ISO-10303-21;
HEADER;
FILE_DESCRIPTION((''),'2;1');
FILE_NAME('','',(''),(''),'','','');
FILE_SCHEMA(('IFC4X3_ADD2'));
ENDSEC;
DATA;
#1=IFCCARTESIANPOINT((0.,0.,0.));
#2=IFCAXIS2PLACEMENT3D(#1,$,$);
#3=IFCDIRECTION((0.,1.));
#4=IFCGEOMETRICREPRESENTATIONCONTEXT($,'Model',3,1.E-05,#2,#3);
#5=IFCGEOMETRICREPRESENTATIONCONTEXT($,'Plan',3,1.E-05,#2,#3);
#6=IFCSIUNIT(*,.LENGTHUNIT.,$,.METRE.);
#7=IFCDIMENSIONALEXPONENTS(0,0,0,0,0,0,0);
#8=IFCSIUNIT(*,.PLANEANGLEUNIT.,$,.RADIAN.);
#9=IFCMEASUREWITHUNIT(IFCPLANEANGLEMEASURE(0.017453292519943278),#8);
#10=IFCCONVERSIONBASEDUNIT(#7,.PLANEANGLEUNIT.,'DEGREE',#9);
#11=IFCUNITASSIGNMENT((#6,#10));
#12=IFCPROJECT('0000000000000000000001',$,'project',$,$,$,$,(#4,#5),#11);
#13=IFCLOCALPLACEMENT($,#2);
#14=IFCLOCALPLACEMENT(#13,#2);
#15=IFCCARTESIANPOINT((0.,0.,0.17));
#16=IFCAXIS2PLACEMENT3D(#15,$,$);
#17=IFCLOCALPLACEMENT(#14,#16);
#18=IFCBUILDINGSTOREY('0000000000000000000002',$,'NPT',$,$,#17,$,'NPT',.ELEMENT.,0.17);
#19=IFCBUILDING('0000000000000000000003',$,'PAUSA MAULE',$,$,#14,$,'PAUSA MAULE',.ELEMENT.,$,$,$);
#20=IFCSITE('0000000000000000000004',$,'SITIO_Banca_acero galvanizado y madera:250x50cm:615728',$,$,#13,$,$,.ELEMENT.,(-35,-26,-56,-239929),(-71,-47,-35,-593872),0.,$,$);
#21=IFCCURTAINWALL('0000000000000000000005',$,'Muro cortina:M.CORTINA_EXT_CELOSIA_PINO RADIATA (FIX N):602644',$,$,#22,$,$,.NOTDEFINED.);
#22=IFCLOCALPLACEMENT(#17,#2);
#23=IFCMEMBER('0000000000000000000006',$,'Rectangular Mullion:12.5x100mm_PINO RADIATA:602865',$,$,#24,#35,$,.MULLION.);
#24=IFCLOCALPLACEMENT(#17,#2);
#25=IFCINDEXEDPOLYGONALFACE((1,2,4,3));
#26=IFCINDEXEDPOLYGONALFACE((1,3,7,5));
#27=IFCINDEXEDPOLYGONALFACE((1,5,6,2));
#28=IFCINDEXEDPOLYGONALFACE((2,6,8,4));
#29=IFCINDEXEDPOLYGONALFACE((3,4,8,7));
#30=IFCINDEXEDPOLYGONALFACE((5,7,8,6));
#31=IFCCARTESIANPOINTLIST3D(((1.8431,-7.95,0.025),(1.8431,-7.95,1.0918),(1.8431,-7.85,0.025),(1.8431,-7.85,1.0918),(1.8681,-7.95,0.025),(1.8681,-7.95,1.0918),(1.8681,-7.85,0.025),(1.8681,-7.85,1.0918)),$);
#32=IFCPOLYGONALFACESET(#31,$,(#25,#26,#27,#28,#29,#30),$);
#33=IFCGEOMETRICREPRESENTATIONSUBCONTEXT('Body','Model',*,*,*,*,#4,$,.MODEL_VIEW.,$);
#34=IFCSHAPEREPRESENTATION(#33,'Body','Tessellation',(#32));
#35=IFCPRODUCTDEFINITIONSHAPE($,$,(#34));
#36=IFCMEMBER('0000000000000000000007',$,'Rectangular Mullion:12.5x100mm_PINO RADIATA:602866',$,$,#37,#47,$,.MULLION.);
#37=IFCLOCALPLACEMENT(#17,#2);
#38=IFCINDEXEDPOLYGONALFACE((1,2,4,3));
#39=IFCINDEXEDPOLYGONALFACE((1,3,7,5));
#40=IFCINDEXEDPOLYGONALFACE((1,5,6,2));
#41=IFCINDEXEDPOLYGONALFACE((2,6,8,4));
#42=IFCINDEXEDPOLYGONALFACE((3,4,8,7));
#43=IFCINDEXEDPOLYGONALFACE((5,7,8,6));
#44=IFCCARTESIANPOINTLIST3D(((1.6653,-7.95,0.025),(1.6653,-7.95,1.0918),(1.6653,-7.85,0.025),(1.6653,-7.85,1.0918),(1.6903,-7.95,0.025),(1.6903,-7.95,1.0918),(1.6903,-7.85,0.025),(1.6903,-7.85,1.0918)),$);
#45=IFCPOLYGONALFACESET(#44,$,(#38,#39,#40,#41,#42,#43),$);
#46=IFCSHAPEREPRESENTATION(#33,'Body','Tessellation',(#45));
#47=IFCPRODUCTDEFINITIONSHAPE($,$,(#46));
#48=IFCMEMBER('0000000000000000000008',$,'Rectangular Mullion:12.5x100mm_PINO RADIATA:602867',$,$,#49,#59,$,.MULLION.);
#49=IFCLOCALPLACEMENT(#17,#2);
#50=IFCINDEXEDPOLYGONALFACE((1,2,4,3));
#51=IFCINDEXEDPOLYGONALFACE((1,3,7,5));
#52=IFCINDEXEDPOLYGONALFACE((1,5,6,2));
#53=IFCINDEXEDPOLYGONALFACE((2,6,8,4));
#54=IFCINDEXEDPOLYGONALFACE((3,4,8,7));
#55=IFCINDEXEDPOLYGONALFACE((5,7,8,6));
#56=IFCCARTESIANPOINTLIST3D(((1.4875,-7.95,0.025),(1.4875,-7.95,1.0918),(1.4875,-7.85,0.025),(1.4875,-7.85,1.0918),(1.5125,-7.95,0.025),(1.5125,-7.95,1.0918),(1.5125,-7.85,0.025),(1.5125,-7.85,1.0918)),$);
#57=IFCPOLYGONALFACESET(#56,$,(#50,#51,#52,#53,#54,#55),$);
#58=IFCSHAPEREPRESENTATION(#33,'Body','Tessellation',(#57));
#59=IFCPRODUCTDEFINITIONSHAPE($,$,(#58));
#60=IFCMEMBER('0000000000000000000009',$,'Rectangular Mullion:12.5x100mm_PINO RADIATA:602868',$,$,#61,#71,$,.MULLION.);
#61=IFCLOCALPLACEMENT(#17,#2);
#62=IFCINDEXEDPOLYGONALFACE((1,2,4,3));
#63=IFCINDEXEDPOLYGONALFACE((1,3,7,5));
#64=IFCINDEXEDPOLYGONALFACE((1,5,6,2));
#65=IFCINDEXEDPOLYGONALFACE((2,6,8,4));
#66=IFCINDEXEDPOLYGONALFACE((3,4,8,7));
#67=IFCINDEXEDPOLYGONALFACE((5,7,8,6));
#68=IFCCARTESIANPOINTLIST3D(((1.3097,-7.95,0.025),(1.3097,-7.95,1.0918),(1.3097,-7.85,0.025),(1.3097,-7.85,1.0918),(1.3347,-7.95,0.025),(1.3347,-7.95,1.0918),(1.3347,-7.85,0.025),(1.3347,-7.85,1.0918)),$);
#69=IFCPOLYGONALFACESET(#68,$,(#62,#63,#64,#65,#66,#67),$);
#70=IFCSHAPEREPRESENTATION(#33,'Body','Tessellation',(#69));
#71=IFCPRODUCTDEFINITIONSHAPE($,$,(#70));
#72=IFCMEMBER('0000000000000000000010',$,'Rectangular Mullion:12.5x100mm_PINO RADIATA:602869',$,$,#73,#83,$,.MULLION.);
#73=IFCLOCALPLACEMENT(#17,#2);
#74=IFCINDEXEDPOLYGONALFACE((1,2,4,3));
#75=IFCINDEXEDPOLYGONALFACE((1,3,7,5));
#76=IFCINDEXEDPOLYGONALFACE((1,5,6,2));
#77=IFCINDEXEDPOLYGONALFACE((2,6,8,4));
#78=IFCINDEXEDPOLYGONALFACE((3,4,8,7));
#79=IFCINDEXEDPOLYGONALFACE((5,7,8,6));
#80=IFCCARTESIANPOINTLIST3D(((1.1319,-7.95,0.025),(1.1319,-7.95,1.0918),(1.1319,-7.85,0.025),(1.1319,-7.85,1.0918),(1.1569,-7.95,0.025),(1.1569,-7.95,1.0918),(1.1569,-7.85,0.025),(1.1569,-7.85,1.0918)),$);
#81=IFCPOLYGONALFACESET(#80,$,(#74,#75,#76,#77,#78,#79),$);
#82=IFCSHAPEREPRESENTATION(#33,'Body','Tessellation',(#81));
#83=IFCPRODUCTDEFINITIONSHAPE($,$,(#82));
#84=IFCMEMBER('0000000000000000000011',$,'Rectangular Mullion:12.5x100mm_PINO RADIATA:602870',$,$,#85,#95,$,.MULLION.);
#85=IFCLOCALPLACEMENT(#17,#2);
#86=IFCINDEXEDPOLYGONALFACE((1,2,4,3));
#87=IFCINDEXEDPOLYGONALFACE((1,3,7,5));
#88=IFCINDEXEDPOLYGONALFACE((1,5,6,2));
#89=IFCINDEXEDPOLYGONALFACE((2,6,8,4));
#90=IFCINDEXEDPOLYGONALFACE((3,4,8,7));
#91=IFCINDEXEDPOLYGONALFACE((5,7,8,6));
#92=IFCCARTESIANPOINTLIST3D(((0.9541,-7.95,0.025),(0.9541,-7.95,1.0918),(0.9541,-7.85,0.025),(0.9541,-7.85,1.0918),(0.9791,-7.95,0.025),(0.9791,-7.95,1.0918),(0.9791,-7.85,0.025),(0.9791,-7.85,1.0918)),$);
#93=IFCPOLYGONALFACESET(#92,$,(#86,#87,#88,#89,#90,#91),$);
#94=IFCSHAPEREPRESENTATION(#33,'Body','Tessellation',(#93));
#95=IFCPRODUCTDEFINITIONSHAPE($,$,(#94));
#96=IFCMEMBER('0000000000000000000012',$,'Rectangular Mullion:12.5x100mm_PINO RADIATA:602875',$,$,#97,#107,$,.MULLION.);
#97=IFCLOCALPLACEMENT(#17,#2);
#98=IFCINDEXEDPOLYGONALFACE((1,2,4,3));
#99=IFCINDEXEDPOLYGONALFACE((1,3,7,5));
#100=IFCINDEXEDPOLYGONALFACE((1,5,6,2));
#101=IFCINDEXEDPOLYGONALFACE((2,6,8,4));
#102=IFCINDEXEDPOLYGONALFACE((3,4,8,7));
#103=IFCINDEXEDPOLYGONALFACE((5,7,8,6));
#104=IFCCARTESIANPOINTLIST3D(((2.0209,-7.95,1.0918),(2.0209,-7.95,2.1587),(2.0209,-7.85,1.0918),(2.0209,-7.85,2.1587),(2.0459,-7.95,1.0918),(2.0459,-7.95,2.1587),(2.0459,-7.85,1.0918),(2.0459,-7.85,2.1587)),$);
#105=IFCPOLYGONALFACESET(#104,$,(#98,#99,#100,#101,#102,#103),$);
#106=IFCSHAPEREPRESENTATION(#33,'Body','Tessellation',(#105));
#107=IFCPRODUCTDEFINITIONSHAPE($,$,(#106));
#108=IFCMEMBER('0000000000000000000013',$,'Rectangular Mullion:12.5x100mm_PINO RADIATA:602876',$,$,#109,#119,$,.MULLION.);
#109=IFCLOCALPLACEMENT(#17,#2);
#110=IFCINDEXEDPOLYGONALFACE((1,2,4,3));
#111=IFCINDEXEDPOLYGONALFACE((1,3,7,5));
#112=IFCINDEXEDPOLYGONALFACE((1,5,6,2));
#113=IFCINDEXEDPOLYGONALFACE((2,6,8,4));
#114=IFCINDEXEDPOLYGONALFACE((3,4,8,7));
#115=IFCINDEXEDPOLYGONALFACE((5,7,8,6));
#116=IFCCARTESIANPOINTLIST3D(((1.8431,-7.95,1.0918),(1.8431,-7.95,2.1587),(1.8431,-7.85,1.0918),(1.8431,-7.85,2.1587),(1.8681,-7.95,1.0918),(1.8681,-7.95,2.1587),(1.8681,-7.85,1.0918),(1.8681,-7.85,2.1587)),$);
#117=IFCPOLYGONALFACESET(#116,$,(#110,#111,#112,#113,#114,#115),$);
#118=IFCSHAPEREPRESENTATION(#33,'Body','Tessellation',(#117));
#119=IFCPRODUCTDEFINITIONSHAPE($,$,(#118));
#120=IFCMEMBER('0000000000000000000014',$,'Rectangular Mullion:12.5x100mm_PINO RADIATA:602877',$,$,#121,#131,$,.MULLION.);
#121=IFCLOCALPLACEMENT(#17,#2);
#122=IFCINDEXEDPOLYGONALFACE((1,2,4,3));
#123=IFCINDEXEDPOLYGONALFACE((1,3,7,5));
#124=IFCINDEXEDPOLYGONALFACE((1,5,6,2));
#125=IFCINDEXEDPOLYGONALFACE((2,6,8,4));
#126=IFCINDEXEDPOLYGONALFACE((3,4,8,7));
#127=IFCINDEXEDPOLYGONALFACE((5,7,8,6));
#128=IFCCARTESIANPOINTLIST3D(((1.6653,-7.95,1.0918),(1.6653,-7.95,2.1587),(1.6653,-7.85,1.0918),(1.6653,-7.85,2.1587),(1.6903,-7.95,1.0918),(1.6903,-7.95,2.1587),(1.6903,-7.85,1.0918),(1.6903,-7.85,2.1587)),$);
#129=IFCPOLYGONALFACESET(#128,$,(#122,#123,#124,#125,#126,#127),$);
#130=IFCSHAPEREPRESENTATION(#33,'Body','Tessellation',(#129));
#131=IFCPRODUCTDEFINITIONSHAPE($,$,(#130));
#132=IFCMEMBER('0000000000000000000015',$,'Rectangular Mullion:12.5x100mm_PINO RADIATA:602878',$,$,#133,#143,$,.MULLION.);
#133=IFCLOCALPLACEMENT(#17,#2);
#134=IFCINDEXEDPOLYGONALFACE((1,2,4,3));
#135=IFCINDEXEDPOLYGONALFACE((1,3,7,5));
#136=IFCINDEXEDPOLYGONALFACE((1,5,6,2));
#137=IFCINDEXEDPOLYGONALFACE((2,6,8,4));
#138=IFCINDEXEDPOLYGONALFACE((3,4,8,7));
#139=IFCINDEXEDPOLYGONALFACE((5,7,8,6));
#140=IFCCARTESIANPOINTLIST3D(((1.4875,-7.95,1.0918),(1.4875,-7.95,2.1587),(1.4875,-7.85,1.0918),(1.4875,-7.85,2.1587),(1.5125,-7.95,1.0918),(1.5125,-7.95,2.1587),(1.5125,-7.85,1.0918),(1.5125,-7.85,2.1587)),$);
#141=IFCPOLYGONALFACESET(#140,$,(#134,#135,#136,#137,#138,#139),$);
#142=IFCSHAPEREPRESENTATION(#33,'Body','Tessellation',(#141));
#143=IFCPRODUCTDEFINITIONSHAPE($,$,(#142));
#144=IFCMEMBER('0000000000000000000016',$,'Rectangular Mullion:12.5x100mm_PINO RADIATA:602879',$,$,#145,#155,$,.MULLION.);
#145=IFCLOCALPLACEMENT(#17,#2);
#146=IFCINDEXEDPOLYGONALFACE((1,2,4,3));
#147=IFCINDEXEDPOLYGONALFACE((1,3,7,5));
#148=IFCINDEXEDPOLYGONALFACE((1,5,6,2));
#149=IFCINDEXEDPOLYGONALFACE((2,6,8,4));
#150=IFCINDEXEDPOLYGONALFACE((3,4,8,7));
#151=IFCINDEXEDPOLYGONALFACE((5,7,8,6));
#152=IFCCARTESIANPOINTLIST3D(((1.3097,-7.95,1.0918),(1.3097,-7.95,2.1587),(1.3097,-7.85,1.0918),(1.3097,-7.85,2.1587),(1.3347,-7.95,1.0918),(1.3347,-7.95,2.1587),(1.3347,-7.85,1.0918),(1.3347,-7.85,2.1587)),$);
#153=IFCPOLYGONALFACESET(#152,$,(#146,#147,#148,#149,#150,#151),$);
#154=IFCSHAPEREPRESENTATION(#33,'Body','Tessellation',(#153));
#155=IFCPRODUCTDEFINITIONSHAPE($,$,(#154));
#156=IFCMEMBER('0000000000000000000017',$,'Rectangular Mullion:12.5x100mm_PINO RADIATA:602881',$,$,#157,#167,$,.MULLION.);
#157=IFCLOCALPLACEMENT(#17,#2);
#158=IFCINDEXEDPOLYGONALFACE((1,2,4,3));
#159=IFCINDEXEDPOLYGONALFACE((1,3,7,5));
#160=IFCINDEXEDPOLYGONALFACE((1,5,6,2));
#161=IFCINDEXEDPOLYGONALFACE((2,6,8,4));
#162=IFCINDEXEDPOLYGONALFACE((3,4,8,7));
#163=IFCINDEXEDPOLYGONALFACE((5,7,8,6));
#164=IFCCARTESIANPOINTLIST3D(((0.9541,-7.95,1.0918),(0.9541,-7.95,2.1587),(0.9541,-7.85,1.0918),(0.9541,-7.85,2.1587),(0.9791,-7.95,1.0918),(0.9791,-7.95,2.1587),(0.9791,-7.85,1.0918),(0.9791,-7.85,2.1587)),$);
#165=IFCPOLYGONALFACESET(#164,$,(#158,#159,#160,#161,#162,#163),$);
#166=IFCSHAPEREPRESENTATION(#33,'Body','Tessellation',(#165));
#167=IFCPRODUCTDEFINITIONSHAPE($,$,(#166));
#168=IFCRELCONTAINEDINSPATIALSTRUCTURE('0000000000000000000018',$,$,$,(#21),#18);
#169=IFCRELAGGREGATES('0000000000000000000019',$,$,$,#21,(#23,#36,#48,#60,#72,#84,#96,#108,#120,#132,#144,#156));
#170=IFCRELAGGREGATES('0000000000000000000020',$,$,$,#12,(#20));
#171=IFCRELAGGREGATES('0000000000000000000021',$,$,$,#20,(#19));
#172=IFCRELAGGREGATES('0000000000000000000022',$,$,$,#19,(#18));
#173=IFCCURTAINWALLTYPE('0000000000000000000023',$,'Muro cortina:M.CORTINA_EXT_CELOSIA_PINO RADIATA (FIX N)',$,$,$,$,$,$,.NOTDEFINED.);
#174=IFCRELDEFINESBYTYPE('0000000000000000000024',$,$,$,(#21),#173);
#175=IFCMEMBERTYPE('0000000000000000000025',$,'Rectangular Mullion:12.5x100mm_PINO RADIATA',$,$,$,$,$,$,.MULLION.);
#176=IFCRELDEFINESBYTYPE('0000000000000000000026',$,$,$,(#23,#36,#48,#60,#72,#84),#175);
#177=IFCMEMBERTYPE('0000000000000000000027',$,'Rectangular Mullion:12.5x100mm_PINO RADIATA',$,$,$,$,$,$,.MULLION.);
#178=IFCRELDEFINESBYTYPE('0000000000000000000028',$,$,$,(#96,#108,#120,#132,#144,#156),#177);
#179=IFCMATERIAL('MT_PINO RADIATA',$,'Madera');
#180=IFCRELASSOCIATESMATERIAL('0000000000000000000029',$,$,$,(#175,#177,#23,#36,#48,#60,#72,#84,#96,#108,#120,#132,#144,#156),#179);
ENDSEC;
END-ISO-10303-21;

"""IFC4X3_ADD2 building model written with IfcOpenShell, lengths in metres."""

from ifc_helpers import new_model, entity, si_unit, converted_unit, direction, frame, frame_2d, origin, origin_2d_with_axis, place, context, subcontext, project, spatial, rectangle, extrude, source, transform, mapped, material, material_profile, profile_set, profile_usage, type_object, type_shapes, element, aggregate, save


model = new_model("IFC4X3_ADD2")

# Units and contexts
model_context = context("Model", 3, precision=1e-05, world=origin(), true_north=direction((0.0, 1.0)))
plan_context = context("Plan", 3, precision=1e-05, world=origin(), true_north=direction((0.0, 1.0)))
body_context = subcontext(model_context, "Body", "Model", "MODEL_VIEW")
ifc_project = project(units=[si_unit("LENGTHUNIT", "METRE"), converted_unit("PLANEANGLEUNIT", "DEGREE", entity("IfcPlaneAngleMeasure", 0.017453292519943278), si_unit("PLANEANGLEUNIT", "RADIAN"), dimensions=[0, 0, 0, 0, 0, 0, 0])], contexts=[model_context, plan_context])

# Site, building, storey
site_placement = place(None, origin())
site = spatial("IfcSite", under=ifc_project, at=site_placement, Name="SITIO_Banca_acero galvanizado y madera:250x50cm:615728", CompositionType="ELEMENT", RefLatitude=(-35, -26, -56, -239929), RefLongitude=(-71, -47, -35, -593872), RefElevation=0.0)
building_placement = place(site_placement, origin())
building = spatial("IfcBuilding", under=site, at=building_placement, Name="PAUSA MAULE", LongName="PAUSA MAULE", CompositionType="ELEMENT")
storey_placement = place(building_placement, frame((0.0, 0.0, 0.17)))
storey = spatial("IfcBuildingStorey", under=building, at=storey_placement, Name="NPT", LongName="NPT", CompositionType="ELEMENT", Elevation=0.17)

# Curtain wall, members
curtain_wall_type = type_object("IfcCurtainWallType", Name="Muro cortina:M.CORTINA_EXT_CELOSIA_PINO RADIATA (FIX N)", PredefinedType="NOTDEFINED")
curtain_wall_placement = place(storey_placement, frame((0.0, 0.0, -0.17)))
curtain_wall = element("IfcCurtainWall", 1, at=curtain_wall_placement, inside=storey, type_object=curtain_wall_type, Name="Muro cortina:M.CORTINA_EXT_CELOSIA_PINO RADIATA (FIX N):602644", PredefinedType="NOTDEFINED")
ifc_material = material(Name="MT_PINO RADIATA", Category="Madera")
ifc_material_profile = material_profile(ifc_material, rectangle(XDim=0.025, YDim=0.1, at=frame_2d((0.0, 0.0), x_axis=(1.0, 0.0))), Name="12.5x100mm_PINO RADIATA")
ifc_profile_set = profile_set([ifc_material_profile], Name="12.5x100mm_PINO RADIATA")
ifc_profile_usage = profile_usage(ifc_profile_set)
member_type_1 = type_object("IfcMemberType", Name="Rectangular Mullion:12.5x100mm_PINO RADIATA", PredefinedType="MULLION", material=ifc_profile_set)
shared_shape_1 = source(origin(), body_context, "Body", "SweptSolid", [
    extrude(rectangle(XDim=0.025, YDim=0.1, at=origin_2d_with_axis()), frame((0.0, 0.0, -1.0668), z_axis=(0.0, 0.0, 1.0), x_axis=(-1.0, 0.0, 0.0)), (0.0, 0.0, 1.0), 1.0668),
])
type_shapes(member_type_1, [shared_shape_1])
member_1_placement = place(curtain_wall_placement, frame((1.8556, -7.9, 0.195), z_axis=(0.0, 0.0, -1.0), x_axis=(-1.0, 0.0, 0.0)))
member_1 = element("IfcMember", 2, at=member_1_placement, type_object=member_type_1, material=ifc_profile_usage, Name="Rectangular Mullion:12.5x100mm_PINO RADIATA:602865", PredefinedType="MULLION", context=body_context, shape_type="MappedRepresentation", body=[
    mapped(shared_shape_1, transform((0.0, 0.0, 0.0), scale=1.0)),
])
member_2_placement = place(curtain_wall_placement, frame((1.6778, -7.9, 0.195), z_axis=(0.0, 0.0, -1.0), x_axis=(-1.0, 0.0, 0.0)))
member_2 = element("IfcMember", 3, at=member_2_placement, type_object=member_type_1, material=ifc_profile_usage, Name="Rectangular Mullion:12.5x100mm_PINO RADIATA:602866", PredefinedType="MULLION", context=body_context, shape_type="MappedRepresentation", body=[
    mapped(shared_shape_1, transform((0.0, 0.0, 0.0), scale=1.0)),
])
member_3_placement = place(curtain_wall_placement, frame((1.5, -7.9, 0.195), z_axis=(0.0, 0.0, -1.0), x_axis=(-1.0, 0.0, 0.0)))
member_3 = element("IfcMember", 4, at=member_3_placement, type_object=member_type_1, material=ifc_profile_usage, Name="Rectangular Mullion:12.5x100mm_PINO RADIATA:602867", PredefinedType="MULLION", context=body_context, shape_type="MappedRepresentation", body=[
    mapped(shared_shape_1, transform((0.0, 0.0, 0.0), scale=1.0)),
])
member_4_placement = place(curtain_wall_placement, frame((1.3222, -7.9, 0.195), z_axis=(0.0, 0.0, -1.0), x_axis=(-1.0, 0.0, 0.0)))
member_4 = element("IfcMember", 5, at=member_4_placement, type_object=member_type_1, material=ifc_profile_usage, Name="Rectangular Mullion:12.5x100mm_PINO RADIATA:602868", PredefinedType="MULLION", context=body_context, shape_type="MappedRepresentation", body=[
    mapped(shared_shape_1, transform((0.0, 0.0, 0.0), scale=1.0)),
])
member_5_placement = place(curtain_wall_placement, frame((1.1444, -7.9, 0.195), z_axis=(0.0, 0.0, -1.0), x_axis=(-1.0, 0.0, 0.0)))
member_5 = element("IfcMember", 6, at=member_5_placement, type_object=member_type_1, material=ifc_profile_usage, Name="Rectangular Mullion:12.5x100mm_PINO RADIATA:602869", PredefinedType="MULLION", context=body_context, shape_type="MappedRepresentation", body=[
    mapped(shared_shape_1, transform((0.0, 0.0, 0.0), scale=1.0)),
])
member_6_placement = place(curtain_wall_placement, frame((0.9666, -7.9, 0.195), z_axis=(0.0, 0.0, -1.0), x_axis=(-1.0, 0.0, 0.0)))
member_6 = element("IfcMember", 7, at=member_6_placement, type_object=member_type_1, material=ifc_profile_usage, Name="Rectangular Mullion:12.5x100mm_PINO RADIATA:602870", PredefinedType="MULLION", context=body_context, shape_type="MappedRepresentation", body=[
    mapped(shared_shape_1, transform((0.0, 0.0, 0.0), scale=1.0)),
])
member_type_2 = type_object("IfcMemberType", Name="Rectangular Mullion:12.5x100mm_PINO RADIATA", PredefinedType="MULLION", material=ifc_profile_set)
shared_shape_2 = source(origin(), body_context, "Body", "SweptSolid", [
    extrude(rectangle(XDim=0.025, YDim=0.1, at=origin_2d_with_axis()), frame((0.0, 0.0, -1.0668), z_axis=(0.0, 0.0, 1.0), x_axis=(-1.0, 0.0, 0.0)), (0.0, 0.0, 1.0), 1.0668),
])
type_shapes(member_type_2, [shared_shape_2])
member_7_placement = place(curtain_wall_placement, frame((2.0334, -7.9, 1.2618), z_axis=(0.0, 0.0, -1.0), x_axis=(-1.0, 0.0, 0.0)))
member_7 = element("IfcMember", 8, at=member_7_placement, type_object=member_type_2, material=ifc_profile_usage, Name="Rectangular Mullion:12.5x100mm_PINO RADIATA:602875", PredefinedType="MULLION", context=body_context, shape_type="MappedRepresentation", body=[
    mapped(shared_shape_2, transform((0.0, 0.0, 0.0), scale=1.0)),
])
member_8_placement = place(curtain_wall_placement, frame((1.8556, -7.9, 1.2618), z_axis=(0.0, 0.0, -1.0), x_axis=(-1.0, 0.0, 0.0)))
member_8 = element("IfcMember", 9, at=member_8_placement, type_object=member_type_2, material=ifc_profile_usage, Name="Rectangular Mullion:12.5x100mm_PINO RADIATA:602876", PredefinedType="MULLION", context=body_context, shape_type="MappedRepresentation", body=[
    mapped(shared_shape_2, transform((0.0, 0.0, 0.0), scale=1.0)),
])
member_9_placement = place(curtain_wall_placement, frame((1.6778, -7.9, 1.2618), z_axis=(0.0, 0.0, -1.0), x_axis=(-1.0, 0.0, 0.0)))
member_9 = element("IfcMember", 10, at=member_9_placement, type_object=member_type_2, material=ifc_profile_usage, Name="Rectangular Mullion:12.5x100mm_PINO RADIATA:602877", PredefinedType="MULLION", context=body_context, shape_type="MappedRepresentation", body=[
    mapped(shared_shape_2, transform((0.0, 0.0, 0.0), scale=1.0)),
])
member_10_placement = place(curtain_wall_placement, frame((1.5, -7.9, 1.2618), z_axis=(0.0, 0.0, -1.0), x_axis=(-1.0, 0.0, 0.0)))
member_10 = element("IfcMember", 11, at=member_10_placement, type_object=member_type_2, material=ifc_profile_usage, Name="Rectangular Mullion:12.5x100mm_PINO RADIATA:602878", PredefinedType="MULLION", context=body_context, shape_type="MappedRepresentation", body=[
    mapped(shared_shape_2, transform((0.0, 0.0, 0.0), scale=1.0)),
])
member_11_placement = place(curtain_wall_placement, frame((1.3222, -7.9, 1.2618), z_axis=(0.0, 0.0, -1.0), x_axis=(-1.0, 0.0, 0.0)))
member_11 = element("IfcMember", 12, at=member_11_placement, type_object=member_type_2, material=ifc_profile_usage, Name="Rectangular Mullion:12.5x100mm_PINO RADIATA:602879", PredefinedType="MULLION", context=body_context, shape_type="MappedRepresentation", body=[
    mapped(shared_shape_2, transform((0.0, 0.0, 0.0), scale=1.0)),
])
member_12_placement = place(curtain_wall_placement, frame((0.9666, -7.9, 1.2618), z_axis=(0.0, 0.0, -1.0), x_axis=(-1.0, 0.0, 0.0)))
member_12 = element("IfcMember", 13, at=member_12_placement, type_object=member_type_2, material=ifc_profile_usage, Name="Rectangular Mullion:12.5x100mm_PINO RADIATA:602881", PredefinedType="MULLION", context=body_context, shape_type="MappedRepresentation", body=[
    mapped(shared_shape_2, transform((0.0, 0.0, 0.0), scale=1.0)),
])
aggregate(curtain_wall, [member_1, member_2, member_3, member_4, member_5, member_6, member_7, member_8, member_9, member_10, member_11, member_12])

save(model, "model.ifc")
